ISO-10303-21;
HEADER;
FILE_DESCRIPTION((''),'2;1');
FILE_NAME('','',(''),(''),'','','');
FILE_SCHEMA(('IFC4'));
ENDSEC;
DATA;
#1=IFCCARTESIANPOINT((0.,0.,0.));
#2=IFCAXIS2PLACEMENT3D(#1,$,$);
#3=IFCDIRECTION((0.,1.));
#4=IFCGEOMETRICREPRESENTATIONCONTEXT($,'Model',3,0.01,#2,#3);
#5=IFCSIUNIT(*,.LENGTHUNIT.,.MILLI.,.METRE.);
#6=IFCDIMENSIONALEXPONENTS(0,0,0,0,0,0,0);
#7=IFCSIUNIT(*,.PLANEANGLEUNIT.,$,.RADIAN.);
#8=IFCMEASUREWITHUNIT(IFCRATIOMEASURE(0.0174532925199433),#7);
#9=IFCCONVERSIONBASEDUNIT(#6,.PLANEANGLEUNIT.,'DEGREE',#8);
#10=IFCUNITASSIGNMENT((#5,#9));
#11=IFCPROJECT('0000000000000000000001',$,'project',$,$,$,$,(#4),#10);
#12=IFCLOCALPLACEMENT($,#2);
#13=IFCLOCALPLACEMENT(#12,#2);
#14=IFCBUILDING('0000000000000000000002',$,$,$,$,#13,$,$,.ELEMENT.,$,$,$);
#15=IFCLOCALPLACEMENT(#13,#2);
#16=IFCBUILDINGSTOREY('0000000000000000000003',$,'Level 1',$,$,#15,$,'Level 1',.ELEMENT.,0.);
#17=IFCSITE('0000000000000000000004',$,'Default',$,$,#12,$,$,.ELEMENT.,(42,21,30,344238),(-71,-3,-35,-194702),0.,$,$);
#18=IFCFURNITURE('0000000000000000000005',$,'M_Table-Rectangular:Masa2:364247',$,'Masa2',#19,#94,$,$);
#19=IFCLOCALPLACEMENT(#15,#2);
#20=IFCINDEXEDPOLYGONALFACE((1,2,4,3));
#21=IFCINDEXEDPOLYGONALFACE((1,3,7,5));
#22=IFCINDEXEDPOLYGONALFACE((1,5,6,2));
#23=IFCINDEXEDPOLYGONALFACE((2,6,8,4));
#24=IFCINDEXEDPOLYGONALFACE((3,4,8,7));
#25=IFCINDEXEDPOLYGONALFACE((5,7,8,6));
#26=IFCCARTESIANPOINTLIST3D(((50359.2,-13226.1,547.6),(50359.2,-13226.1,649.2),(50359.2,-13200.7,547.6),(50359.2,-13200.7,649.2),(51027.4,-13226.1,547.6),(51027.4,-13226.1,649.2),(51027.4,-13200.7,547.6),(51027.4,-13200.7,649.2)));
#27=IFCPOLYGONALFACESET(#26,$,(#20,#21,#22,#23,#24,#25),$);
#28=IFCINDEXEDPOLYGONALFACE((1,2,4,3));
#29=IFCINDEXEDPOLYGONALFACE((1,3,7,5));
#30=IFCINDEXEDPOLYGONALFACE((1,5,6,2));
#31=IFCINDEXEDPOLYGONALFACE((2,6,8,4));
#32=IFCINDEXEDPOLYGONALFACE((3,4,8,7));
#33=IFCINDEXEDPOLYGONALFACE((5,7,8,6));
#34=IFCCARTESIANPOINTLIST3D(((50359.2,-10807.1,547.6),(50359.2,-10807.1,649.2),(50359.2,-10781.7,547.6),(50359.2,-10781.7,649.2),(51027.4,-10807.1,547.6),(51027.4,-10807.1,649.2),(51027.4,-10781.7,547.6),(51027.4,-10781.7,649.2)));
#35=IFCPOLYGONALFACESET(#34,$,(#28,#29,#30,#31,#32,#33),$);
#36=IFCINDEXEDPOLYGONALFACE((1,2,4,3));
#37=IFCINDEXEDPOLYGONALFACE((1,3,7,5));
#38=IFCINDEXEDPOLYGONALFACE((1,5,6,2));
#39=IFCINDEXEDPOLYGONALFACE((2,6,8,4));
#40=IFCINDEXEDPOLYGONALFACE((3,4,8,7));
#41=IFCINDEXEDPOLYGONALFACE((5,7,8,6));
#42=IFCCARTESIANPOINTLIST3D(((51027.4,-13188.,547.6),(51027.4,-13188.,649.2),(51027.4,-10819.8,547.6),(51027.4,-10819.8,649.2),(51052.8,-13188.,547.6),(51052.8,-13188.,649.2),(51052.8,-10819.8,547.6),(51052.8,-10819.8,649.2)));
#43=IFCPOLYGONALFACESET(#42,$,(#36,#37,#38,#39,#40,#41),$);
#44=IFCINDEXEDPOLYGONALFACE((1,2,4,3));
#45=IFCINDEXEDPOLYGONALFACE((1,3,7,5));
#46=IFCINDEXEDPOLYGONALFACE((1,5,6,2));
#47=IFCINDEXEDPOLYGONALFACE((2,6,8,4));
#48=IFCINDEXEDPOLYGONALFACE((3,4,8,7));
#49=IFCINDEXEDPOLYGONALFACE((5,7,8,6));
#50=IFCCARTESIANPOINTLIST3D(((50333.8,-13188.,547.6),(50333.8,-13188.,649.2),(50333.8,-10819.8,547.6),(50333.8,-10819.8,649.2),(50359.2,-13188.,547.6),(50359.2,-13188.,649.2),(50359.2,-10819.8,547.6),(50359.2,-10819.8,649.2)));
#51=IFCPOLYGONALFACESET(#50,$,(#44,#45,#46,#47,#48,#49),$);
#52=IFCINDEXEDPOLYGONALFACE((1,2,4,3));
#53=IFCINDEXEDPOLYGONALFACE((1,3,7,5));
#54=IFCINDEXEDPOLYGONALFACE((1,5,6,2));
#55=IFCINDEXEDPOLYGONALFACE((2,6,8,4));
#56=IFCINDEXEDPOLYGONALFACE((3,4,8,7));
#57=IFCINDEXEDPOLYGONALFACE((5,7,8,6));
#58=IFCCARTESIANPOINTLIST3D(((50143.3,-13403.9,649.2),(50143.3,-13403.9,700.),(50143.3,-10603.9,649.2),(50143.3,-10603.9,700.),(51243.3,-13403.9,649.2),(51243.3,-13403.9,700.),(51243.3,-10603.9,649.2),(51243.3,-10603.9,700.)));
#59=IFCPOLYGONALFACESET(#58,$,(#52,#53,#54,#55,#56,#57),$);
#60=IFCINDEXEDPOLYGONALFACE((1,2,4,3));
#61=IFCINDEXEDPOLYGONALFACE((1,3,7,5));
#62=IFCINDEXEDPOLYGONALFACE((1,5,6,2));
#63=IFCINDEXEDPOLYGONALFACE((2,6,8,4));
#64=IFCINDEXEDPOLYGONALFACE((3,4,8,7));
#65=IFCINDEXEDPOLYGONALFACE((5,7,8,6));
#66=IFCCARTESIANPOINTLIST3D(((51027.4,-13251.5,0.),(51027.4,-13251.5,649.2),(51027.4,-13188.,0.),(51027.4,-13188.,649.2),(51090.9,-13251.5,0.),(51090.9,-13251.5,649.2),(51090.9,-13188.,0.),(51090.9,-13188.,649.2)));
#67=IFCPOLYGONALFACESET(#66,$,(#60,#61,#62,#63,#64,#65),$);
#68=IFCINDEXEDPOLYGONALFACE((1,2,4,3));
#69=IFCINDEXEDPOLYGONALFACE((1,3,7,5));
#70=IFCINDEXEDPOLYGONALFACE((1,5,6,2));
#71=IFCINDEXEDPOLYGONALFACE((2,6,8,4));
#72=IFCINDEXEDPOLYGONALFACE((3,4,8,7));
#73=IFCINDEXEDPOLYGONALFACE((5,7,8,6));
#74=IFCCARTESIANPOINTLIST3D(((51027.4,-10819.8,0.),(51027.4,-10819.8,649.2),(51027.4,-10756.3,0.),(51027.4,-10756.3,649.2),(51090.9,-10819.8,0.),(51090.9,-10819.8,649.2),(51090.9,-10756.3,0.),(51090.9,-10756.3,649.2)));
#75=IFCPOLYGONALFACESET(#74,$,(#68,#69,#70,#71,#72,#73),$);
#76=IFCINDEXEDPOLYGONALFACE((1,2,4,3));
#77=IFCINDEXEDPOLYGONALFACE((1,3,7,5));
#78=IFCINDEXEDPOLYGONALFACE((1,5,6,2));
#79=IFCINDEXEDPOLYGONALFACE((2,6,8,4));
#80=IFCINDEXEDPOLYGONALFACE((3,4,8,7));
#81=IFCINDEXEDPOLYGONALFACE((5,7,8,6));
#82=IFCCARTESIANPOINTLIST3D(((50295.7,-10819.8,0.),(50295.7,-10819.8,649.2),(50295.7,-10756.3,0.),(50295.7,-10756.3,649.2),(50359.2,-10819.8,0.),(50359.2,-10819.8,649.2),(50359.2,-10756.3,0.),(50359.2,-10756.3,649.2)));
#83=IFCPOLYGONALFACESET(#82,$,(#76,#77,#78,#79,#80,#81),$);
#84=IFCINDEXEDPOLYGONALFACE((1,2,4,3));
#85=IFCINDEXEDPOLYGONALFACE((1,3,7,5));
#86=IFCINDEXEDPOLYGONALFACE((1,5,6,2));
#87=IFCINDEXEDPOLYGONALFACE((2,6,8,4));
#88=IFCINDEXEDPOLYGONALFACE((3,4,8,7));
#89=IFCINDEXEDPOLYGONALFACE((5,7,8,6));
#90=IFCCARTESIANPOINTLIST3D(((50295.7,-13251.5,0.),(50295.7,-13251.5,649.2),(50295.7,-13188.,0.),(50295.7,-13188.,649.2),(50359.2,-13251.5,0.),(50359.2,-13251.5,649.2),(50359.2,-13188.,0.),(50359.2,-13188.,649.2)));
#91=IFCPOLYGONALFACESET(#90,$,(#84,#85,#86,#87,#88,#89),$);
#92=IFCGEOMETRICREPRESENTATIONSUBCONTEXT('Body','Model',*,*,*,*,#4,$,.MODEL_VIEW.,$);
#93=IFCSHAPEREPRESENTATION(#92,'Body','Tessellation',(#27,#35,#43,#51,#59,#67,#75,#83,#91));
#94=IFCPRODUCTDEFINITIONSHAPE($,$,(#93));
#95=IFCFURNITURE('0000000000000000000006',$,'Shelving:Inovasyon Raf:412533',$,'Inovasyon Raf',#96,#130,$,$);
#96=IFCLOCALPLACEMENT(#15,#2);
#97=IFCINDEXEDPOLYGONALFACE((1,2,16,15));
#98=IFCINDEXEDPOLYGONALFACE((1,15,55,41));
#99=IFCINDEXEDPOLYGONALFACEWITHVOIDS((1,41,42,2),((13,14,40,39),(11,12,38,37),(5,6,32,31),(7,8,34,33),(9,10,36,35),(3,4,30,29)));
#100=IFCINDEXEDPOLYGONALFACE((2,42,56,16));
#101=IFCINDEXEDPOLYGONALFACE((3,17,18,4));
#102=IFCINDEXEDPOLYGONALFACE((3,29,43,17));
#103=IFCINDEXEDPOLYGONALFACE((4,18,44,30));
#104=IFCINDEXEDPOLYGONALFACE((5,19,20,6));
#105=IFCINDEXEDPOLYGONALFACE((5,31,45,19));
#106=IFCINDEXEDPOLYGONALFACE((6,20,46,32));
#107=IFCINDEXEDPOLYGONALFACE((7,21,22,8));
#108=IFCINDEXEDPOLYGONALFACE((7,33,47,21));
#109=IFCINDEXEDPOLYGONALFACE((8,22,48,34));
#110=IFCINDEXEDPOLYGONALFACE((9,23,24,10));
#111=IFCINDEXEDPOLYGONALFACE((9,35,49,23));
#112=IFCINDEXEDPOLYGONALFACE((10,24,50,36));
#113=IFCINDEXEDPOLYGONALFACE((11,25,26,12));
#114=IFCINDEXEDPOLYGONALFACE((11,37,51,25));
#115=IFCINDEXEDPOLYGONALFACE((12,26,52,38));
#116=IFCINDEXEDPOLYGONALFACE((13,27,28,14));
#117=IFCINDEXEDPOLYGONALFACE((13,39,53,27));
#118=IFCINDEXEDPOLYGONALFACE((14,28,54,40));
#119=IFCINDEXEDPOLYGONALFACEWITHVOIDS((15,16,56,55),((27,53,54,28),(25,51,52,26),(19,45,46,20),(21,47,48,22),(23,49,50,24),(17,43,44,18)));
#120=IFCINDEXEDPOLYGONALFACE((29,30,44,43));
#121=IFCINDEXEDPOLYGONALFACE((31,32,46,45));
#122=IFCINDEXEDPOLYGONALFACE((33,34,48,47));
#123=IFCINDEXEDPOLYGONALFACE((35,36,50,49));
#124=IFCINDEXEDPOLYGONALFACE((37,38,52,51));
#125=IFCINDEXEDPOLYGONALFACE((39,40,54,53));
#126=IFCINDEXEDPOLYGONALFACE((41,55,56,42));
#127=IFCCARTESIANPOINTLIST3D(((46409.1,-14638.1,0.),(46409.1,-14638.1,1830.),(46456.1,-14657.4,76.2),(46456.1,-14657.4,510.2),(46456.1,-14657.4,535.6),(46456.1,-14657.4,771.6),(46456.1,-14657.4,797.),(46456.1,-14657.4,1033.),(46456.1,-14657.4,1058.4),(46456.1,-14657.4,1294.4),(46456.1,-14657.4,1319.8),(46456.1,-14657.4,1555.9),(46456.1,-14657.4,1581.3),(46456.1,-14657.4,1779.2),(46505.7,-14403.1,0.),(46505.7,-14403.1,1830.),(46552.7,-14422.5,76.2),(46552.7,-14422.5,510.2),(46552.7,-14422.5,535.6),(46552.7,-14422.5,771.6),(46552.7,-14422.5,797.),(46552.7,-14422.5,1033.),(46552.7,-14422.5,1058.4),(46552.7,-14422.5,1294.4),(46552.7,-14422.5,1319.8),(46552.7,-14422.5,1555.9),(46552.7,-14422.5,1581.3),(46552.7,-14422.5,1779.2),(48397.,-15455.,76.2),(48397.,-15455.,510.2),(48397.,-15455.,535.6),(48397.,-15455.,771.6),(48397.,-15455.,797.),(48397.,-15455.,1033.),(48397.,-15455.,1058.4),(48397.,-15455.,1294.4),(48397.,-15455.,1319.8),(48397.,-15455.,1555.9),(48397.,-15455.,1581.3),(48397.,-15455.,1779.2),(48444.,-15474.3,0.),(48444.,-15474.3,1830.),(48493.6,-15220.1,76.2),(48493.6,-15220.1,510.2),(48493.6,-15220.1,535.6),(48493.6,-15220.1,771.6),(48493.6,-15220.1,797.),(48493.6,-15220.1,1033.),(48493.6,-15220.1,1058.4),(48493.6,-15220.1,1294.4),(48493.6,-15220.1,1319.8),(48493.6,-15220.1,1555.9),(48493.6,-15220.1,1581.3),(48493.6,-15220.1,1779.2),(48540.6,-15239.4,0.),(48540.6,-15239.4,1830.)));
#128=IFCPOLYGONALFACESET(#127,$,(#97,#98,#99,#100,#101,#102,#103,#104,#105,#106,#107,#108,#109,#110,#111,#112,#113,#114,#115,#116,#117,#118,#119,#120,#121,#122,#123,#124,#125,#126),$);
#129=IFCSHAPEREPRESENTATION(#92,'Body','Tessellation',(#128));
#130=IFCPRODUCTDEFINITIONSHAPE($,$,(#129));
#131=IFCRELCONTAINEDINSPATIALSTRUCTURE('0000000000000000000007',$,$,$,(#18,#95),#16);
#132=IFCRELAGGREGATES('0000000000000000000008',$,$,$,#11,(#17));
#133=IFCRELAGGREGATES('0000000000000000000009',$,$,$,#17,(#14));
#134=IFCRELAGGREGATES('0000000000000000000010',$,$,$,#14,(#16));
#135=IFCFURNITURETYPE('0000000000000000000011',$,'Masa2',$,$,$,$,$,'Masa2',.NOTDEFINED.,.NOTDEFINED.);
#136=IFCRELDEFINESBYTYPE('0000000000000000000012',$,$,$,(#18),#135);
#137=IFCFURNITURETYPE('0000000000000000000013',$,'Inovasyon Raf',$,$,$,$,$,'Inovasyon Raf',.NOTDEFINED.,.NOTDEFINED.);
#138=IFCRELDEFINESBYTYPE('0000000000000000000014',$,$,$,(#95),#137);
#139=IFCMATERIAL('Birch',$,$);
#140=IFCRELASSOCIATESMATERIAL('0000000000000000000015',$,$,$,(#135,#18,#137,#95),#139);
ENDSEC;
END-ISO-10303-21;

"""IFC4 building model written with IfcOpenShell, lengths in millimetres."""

from ifc_helpers import new_model, entity, si_unit, converted_unit, direction, frame, frame_2d, origin, origin_2d_with_axis, place, context, subcontext, project, spatial, polyline, rectangle, outline, extrude, source, transform, mapped, material, type_object, type_shapes, element, save


model = new_model("IFC4")

# Units and contexts
model_context = context("Model", 3, precision=0.01, world=origin(), true_north=direction((0.0, 1.0)))
body_context = subcontext(model_context, "Body", "Model", "MODEL_VIEW")
ifc_project = project(units=[si_unit("LENGTHUNIT", "METRE", prefix="MILLI"), converted_unit("PLANEANGLEUNIT", "DEGREE", entity("IfcRatioMeasure", 0.0174532925199433), si_unit("PLANEANGLEUNIT", "RADIAN"), dimensions=[0, 0, 0, 0, 0, 0, 0])], contexts=[model_context])

# Site, building, storey
site_placement = place(None, origin())
site = spatial("IfcSite", under=ifc_project, at=site_placement, Name="Default", CompositionType="ELEMENT", RefLatitude=(42, 21, 30, 344238), RefLongitude=(-71, -3, -35, -194702), RefElevation=0.0)
building_placement = place(site_placement, origin())
building = spatial("IfcBuilding", under=site, at=building_placement, CompositionType="ELEMENT")
storey_placement = place(building_placement, origin())
storey = spatial("IfcBuildingStorey", under=building, at=storey_placement, Name="Level 1", LongName="Level 1", CompositionType="ELEMENT", Elevation=0.0)

# Furniture
ifc_material_1 = material(Name="Birch")
furniture_type_1 = type_object("IfcFurnitureType", Name="Masa2", ElementType="Masa2", AssemblyPlace="NOTDEFINED", PredefinedType="NOTDEFINED", material=ifc_material_1)
shared_shape_1 = source(origin(), body_context, "Body", "SweptSolid", [
    extrude(rectangle(XDim=25.4, YDim=668.2, at=origin_2d_with_axis()), frame((1209.5, 0.0, 547.6)), (0.0, 0.0, 1.0), 101.6),
    extrude(rectangle(XDim=668.2, YDim=25.4, at=origin_2d_with_axis()), frame((-1209.5, 0.0, 547.6), z_axis=(0.0, 0.0, 1.0), x_axis=(0.0, 1.0, 0.0)), (0.0, 0.0, 1.0), 101.6),
    extrude(rectangle(XDim=2368.2, YDim=25.4, at=frame_2d((0.0, 0.0), x_axis=(1.0, 0.0))), frame((0.0, 346.8, 547.6), z_axis=(0.0, 0.0, 1.0), x_axis=(-1.0, 0.0, 0.0)), (0.0, 0.0, 1.0), 101.6),
    extrude(rectangle(XDim=25.4, YDim=2368.2, at=origin_2d_with_axis()), frame((0.0, -346.8, 547.6), z_axis=(0.0, 0.0, 1.0), x_axis=(0.0, 1.0, 0.0)), (0.0, 0.0, 1.0), 101.6),
    extrude(rectangle(XDim=2800.0, YDim=1100.0, at=origin_2d_with_axis()), frame((0.0, 0.0, 649.2), z_axis=(0.0, 0.0, 1.0), x_axis=(-1.0, 0.0, 0.0)), (0.0, 0.0, 1.0), 50.8),
    extrude(rectangle(XDim=63.5, YDim=63.5, at=origin_2d_with_axis()), frame((1215.8, 365.9, 0.0), z_axis=(0.0, 0.0, 1.0), x_axis=(0.0, -1.0, 0.0)), (0.0, 0.0, 1.0), 649.2),
    extrude(rectangle(XDim=63.5, YDim=63.5, at=frame_2d((0.0, 0.0), x_axis=(1.0, 0.0))), frame((-1215.8, 365.9, 0.0), z_axis=(0.0, 0.0, 1.0), x_axis=(-1.0, 0.0, 0.0)), (0.0, 0.0, 1.0), 649.2),
    extrude(rectangle(XDim=63.5, YDim=63.5, at=origin_2d_with_axis()), frame((-1215.8, -365.9, 0.0), z_axis=(0.0, 0.0, 1.0), x_axis=(0.0, 1.0, 0.0)), (0.0, 0.0, 1.0), 649.2),
    extrude(rectangle(XDim=63.5, YDim=63.5, at=frame_2d((0.0, 0.0), x_axis=(1.0, 0.0))), frame((1215.8, -365.9, 0.0)), (0.0, 0.0, 1.0), 649.2),
])
type_shapes(furniture_type_1, [shared_shape_1])
furniture_1_placement = place(storey_placement, frame((50693.3, -12003.9, 0.0), z_axis=(0.0, 0.0, 1.0), x_axis=(0.0, -1.0, 0.0)))
element("IfcFurniture", 1, at=furniture_1_placement, inside=storey, type_object=furniture_type_1, material=ifc_material_1, Name="M_Table-Rectangular:Masa2:364247", ObjectType="Masa2", context=body_context, shape_type="MappedRepresentation", body=[
    mapped(shared_shape_1, transform((0.0, 0.0, 0.0), scale=1.0)),
])
furniture_type_2 = type_object("IfcFurnitureType", Name="Inovasyon Raf", ElementType="Inovasyon Raf", AssemblyPlace="NOTDEFINED", PredefinedType="NOTDEFINED", material=ifc_material_1)
shared_shape_2 = source(origin(), body_context, "Body", "SweptSolid", [
    extrude(outline(polyline([(-1100.0, -915.0), (1100.0, -915.0), (1100.0, 915.0), (-1100.0, 915.0), (-1100.0, -915.0)]), holes=[polyline([(-1049.2, 864.2), (1049.2, 864.2), (1049.2, 666.3), (-1049.2, 666.3), (-1049.2, 864.2)]), polyline([(-1049.2, -838.8), (-1049.2, -404.8), (1049.2, -404.8), (1049.2, -838.8), (-1049.2, -838.8)]), polyline([(1049.2, 143.4), (-1049.2, 143.4), (-1049.2, 379.4), (1049.2, 379.4), (1049.2, 143.4)]), polyline([(-1049.2, 640.9), (1049.2, 640.9), (1049.2, 404.8), (-1049.2, 404.8), (-1049.2, 640.9)]), polyline([(-1049.2, 118.0), (1049.2, 118.0), (1049.2, -118.0), (-1049.2, -118.0), (-1049.2, 118.0)]), polyline([(-1049.2, -143.4), (1049.2, -143.4), (1049.2, -379.4), (-1049.2, -379.4), (-1049.2, -143.4)])]), frame((0.0, -431.8, 915.0), z_axis=(0.0, 1.0, 0.0), x_axis=(-1.0, 0.0, 0.0)), (0.0, 0.0, 1.0), 254.0),
])
type_shapes(furniture_type_2, [shared_shape_2])
furniture_2_placement = place(storey_placement, frame((47590.7, -14656.8, 0.0), z_axis=(0.0, 0.0, 1.0), x_axis=(0.924944, -0.380102, 0.0)))
element("IfcFurniture", 2, at=furniture_2_placement, inside=storey, type_object=furniture_type_2, material=ifc_material_1, Name="Shelving:Inovasyon Raf:412533", ObjectType="Inovasyon Raf", context=body_context, shape_type="MappedRepresentation", body=[
    mapped(shared_shape_2, transform((0.0, 0.0, 0.0), scale=1.0)),
])

save(model, "model.ifc")
